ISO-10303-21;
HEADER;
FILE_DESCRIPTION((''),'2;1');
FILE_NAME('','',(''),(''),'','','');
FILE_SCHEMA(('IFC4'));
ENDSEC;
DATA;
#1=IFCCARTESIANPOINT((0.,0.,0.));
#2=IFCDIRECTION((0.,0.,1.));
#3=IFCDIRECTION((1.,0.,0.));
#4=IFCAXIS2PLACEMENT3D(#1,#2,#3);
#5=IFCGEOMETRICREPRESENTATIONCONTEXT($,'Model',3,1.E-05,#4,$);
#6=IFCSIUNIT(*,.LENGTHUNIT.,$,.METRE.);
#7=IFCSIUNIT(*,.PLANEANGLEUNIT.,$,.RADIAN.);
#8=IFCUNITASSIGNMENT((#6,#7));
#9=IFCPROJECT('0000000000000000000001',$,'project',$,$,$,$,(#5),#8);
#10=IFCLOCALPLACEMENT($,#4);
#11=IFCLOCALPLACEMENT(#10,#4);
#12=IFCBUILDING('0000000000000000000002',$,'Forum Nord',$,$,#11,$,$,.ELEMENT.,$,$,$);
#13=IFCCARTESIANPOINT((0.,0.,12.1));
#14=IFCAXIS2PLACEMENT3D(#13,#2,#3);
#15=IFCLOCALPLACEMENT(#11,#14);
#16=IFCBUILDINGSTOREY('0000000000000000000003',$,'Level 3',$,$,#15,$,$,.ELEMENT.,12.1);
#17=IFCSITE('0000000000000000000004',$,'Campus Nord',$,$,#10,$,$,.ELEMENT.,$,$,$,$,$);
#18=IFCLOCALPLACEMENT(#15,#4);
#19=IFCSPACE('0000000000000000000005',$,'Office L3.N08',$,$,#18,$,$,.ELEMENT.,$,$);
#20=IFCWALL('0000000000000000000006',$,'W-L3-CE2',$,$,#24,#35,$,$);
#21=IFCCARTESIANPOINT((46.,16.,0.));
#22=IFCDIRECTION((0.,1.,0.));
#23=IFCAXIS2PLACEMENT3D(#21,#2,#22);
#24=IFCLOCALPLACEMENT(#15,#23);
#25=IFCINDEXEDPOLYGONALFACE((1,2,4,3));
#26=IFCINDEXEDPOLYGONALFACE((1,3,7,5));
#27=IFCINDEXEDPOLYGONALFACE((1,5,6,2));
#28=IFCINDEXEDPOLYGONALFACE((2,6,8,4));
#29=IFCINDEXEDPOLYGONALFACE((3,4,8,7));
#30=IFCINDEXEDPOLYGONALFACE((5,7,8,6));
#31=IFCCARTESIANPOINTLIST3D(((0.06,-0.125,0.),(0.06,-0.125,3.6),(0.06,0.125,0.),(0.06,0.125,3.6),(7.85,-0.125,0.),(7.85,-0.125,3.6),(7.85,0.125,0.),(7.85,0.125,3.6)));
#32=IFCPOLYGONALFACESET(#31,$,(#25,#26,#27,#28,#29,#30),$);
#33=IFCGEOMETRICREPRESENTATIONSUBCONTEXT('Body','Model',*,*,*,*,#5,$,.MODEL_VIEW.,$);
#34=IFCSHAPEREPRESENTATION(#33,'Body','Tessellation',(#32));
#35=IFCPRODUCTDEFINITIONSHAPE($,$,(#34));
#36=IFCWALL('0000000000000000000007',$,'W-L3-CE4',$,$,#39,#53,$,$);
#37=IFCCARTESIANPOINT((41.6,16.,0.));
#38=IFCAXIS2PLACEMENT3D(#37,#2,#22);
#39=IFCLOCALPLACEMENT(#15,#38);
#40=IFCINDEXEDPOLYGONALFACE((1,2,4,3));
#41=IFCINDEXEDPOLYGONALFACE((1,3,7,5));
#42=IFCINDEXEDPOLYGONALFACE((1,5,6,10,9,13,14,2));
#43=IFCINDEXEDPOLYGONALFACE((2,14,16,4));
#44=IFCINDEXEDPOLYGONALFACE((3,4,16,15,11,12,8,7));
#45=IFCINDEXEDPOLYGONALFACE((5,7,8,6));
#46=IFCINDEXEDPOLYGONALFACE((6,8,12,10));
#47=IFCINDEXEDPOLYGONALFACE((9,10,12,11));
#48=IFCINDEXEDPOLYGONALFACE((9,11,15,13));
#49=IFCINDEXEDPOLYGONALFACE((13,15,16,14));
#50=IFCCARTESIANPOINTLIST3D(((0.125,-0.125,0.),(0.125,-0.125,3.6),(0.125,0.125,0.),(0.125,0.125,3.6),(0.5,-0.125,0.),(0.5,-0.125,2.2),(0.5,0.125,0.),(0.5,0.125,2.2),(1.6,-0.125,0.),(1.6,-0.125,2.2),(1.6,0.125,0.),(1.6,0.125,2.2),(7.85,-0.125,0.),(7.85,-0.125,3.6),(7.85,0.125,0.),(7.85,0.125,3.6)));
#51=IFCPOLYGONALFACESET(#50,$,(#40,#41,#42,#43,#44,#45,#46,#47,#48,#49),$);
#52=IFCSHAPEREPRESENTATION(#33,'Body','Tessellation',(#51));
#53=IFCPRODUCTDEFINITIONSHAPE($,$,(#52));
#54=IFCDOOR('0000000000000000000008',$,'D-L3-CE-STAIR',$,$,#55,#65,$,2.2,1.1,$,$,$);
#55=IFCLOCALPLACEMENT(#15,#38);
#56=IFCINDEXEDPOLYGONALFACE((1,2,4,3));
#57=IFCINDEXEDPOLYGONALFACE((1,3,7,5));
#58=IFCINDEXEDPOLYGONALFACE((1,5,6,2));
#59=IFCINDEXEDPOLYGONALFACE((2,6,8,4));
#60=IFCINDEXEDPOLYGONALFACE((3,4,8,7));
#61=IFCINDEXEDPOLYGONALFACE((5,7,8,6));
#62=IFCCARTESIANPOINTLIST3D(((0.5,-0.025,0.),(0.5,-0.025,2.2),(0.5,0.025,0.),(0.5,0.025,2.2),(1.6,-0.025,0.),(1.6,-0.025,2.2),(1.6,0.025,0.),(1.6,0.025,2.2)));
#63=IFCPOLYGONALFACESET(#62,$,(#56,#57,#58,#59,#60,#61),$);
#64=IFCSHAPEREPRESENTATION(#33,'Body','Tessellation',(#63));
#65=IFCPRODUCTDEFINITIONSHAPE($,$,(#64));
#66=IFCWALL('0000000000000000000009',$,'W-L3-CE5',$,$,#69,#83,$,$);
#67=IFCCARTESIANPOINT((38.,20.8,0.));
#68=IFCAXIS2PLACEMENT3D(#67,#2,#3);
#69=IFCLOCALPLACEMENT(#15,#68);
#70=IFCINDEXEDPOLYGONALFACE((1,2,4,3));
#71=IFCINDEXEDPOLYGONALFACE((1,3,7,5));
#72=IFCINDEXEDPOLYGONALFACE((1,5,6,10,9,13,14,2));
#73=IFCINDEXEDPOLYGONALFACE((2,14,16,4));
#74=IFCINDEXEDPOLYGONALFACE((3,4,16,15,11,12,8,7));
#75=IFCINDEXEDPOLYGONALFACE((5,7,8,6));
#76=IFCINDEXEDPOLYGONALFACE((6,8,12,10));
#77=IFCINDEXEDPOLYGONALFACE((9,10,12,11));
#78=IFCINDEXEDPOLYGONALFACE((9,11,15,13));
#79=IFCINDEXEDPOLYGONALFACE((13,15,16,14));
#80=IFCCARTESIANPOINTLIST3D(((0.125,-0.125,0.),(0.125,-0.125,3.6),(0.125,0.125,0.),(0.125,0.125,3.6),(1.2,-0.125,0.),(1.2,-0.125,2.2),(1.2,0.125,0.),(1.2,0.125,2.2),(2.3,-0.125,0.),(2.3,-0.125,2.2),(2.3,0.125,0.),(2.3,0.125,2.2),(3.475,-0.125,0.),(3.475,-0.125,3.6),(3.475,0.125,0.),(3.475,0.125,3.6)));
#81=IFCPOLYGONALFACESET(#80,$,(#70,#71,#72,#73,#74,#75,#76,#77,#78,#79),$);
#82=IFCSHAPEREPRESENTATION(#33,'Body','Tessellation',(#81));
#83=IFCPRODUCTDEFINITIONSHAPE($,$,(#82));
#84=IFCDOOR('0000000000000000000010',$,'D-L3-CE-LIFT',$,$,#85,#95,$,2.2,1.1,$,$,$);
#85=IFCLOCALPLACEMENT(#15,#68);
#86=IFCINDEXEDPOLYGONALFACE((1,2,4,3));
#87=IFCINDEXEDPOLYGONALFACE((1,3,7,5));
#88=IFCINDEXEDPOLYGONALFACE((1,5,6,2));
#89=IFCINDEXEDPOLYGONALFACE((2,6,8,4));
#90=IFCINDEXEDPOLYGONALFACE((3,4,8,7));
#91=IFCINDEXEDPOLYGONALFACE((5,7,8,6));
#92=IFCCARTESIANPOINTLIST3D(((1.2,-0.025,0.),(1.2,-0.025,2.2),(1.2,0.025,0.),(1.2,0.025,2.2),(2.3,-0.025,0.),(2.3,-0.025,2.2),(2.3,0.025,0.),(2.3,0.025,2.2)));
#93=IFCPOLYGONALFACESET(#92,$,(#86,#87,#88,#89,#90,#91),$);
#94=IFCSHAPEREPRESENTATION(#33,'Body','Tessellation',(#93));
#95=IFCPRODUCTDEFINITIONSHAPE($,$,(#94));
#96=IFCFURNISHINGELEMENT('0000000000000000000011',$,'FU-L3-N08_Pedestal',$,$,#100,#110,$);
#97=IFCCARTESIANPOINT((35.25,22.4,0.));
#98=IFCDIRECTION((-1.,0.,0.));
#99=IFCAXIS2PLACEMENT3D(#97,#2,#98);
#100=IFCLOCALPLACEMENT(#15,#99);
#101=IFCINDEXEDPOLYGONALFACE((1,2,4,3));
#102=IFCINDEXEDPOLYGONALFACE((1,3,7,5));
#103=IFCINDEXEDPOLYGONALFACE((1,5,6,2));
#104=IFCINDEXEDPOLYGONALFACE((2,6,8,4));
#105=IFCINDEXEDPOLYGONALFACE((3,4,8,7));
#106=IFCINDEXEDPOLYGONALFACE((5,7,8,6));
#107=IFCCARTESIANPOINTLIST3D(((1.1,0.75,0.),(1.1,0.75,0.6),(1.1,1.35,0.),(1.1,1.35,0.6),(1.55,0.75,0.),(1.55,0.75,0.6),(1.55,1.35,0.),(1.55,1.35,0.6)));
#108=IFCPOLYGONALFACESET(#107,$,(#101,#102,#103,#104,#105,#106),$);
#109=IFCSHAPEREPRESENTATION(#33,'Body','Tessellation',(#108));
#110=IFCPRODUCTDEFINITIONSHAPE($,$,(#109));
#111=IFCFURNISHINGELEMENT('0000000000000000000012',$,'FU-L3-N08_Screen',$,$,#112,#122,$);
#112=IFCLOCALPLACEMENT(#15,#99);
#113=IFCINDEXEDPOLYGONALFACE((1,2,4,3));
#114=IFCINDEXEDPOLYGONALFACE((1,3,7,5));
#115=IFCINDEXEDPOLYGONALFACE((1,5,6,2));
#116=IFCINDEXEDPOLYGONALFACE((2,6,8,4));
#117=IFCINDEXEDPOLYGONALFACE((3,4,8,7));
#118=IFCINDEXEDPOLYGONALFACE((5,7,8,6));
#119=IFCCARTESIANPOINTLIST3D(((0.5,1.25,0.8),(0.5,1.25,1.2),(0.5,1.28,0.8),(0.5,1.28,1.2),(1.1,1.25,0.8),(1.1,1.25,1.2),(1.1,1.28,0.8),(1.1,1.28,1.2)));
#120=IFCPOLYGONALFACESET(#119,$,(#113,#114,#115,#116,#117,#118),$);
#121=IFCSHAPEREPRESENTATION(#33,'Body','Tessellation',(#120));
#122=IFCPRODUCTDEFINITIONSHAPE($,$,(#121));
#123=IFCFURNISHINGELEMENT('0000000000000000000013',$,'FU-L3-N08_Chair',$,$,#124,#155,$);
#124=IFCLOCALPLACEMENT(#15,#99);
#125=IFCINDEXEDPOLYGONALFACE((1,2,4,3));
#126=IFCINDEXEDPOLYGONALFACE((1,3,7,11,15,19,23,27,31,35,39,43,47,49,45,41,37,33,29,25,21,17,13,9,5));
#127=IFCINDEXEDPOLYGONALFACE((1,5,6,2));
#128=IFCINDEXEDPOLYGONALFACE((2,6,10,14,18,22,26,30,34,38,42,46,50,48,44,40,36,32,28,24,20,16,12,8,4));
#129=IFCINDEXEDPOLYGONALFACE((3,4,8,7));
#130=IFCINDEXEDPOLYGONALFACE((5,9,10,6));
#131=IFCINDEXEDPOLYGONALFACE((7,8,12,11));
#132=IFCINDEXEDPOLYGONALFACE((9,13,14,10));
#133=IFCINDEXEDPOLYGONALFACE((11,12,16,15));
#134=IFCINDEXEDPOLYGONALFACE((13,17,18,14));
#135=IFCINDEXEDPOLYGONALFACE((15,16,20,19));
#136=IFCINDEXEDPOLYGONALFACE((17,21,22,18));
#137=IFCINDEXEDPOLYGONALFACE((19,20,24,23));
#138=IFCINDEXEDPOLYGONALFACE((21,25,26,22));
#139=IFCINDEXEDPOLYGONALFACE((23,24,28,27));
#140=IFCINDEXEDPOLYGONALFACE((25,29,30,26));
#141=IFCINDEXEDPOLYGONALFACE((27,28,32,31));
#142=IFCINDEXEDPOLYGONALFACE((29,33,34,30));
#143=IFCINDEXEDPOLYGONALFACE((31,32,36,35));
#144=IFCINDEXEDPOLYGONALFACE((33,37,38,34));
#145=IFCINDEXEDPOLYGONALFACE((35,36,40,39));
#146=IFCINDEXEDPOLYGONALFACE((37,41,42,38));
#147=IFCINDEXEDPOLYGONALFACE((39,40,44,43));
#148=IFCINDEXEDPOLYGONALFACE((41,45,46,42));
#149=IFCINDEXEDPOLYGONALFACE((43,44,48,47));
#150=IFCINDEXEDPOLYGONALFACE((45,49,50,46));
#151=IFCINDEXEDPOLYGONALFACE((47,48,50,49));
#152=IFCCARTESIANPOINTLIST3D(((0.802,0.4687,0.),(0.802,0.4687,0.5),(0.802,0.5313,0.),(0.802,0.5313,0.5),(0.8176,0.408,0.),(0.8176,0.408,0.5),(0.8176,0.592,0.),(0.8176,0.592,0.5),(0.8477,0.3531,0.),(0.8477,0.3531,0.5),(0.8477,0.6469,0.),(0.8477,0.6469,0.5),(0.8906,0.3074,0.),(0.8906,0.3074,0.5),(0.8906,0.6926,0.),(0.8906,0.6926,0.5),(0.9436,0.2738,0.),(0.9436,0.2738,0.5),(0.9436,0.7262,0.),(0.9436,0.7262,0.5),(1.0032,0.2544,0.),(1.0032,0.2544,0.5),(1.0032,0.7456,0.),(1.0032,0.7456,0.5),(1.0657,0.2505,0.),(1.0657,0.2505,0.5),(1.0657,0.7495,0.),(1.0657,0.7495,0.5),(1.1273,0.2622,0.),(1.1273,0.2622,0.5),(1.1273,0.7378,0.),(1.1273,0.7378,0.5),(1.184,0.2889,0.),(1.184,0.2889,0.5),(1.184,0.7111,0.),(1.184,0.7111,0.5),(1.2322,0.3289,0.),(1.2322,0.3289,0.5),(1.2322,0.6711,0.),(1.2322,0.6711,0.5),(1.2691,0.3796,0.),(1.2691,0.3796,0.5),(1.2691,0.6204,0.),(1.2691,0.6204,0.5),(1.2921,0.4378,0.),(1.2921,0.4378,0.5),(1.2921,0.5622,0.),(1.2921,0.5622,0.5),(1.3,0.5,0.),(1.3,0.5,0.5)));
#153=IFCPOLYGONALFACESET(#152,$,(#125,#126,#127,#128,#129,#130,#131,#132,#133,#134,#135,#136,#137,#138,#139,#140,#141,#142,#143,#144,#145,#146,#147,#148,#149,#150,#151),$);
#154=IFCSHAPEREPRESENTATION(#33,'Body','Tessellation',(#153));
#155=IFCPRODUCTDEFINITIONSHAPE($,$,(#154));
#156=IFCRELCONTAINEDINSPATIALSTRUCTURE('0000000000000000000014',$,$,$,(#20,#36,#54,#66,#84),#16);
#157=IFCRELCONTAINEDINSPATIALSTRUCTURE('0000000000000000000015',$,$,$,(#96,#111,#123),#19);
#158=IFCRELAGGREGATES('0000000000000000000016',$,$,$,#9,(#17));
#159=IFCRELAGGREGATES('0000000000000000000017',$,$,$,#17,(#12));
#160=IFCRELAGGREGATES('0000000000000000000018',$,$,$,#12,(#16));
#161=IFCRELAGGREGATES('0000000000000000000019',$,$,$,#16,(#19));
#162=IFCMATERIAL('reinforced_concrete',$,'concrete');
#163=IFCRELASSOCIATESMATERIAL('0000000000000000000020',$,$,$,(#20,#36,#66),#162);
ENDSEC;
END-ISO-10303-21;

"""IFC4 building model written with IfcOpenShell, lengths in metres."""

from ifc_helpers import new_model, si_unit, frame, frame_2d, origin_with_axes, place, context, subcontext, project, spatial, polyline, rectangle, circle, outline, extrude, material, element, fill, save


model = new_model("IFC4")

# Units and contexts
model_context = context("Model", 3, precision=1e-05, world=origin_with_axes())
body_context = subcontext(model_context, "Body", "Model", "MODEL_VIEW")
ifc_project = project(units=[si_unit("LENGTHUNIT", "METRE"), si_unit("PLANEANGLEUNIT", "RADIAN")], contexts=[model_context])

# Site, building, storey
site_placement = place(None, origin_with_axes())
site = spatial("IfcSite", under=ifc_project, at=site_placement, Name="Campus Nord", CompositionType="ELEMENT")
building_placement = place(site_placement, origin_with_axes())
building = spatial("IfcBuilding", under=site, at=building_placement, Name="Forum Nord", CompositionType="ELEMENT")
storey_placement = place(building_placement, frame((0.0, 0.0, 12.1), z_axis=(0.0, 0.0, 1.0), x_axis=(1.0, 0.0, 0.0)))
storey = spatial("IfcBuildingStorey", under=building, at=storey_placement, Name="Level 3", CompositionType="ELEMENT", Elevation=12.1)

# Wall
ifc_material_1 = material(Name="reinforced_concrete", Category="concrete")
wall_1_placement = place(storey_placement, frame((46.0, 16.0, 0.0), z_axis=(0.0, 0.0, 1.0), x_axis=(0.0, 1.0, 0.0)))
element("IfcWall", 1, at=wall_1_placement, inside=storey, material=ifc_material_1, Name="W-L3-CE2", context=body_context, shape_type="SweptSolid", body=[
    extrude(outline(polyline([(0.06, -0.125), (7.85, -0.125), (7.85, 0.125), (0.06, 0.125), (0.06, -0.125)])), origin_with_axes(), (0.0, 0.0, 1.0), 3.6),
])

# Walls, openings, doors
wall_2_placement = place(storey_placement, frame((41.6, 16.0, 0.0), z_axis=(0.0, 0.0, 1.0), x_axis=(0.0, 1.0, 0.0)))
wall_2 = element("IfcWall", 2, at=wall_2_placement, inside=storey, material=ifc_material_1, Name="W-L3-CE4", context=body_context, shape_type="SweptSolid", body=[
    extrude(outline(polyline([(0.125, -0.125), (7.85, -0.125), (7.85, 0.125), (0.125, 0.125), (0.125, -0.125)])), origin_with_axes(), (0.0, 0.0, 1.0), 3.6),
])
opening_1_placement = place(storey_placement, frame((41.6, 16.0, 0.0), z_axis=(0.0, 0.0, 1.0), x_axis=(0.0, 1.0, 0.0)))
opening_1 = element("IfcOpeningElement", 3, at=opening_1_placement, cuts=wall_2, context=body_context, shape_type="SweptSolid", body=[
    extrude(rectangle(XDim=1.1, YDim=0.25, at=frame_2d((1.05, 0.0), x_axis=(1.0, 0.0))), origin_with_axes(), (0.0, 0.0, 1.0), 2.2),
])
door_1_placement = place(storey_placement, frame((41.6, 16.0, 0.0), z_axis=(0.0, 0.0, 1.0), x_axis=(0.0, 1.0, 0.0)))
door_1 = element("IfcDoor", 4, at=door_1_placement, inside=storey, Name="D-L3-CE-STAIR", OverallHeight=2.2, OverallWidth=1.1, context=body_context, shape_type="SweptSolid", body=[
    extrude(rectangle(XDim=1.1, YDim=0.05, at=frame_2d((1.05, 0.0), x_axis=(1.0, 0.0))), origin_with_axes(), (0.0, 0.0, 1.0), 2.2),
])
fill(opening_1, door_1)
wall_3_placement = place(storey_placement, frame((38.0, 20.8, 0.0), z_axis=(0.0, 0.0, 1.0), x_axis=(1.0, 0.0, 0.0)))
wall_3 = element("IfcWall", 5, at=wall_3_placement, inside=storey, material=ifc_material_1, Name="W-L3-CE5", context=body_context, shape_type="SweptSolid", body=[
    extrude(outline(polyline([(0.125, -0.125), (3.475, -0.125), (3.475, 0.125), (0.125, 0.125), (0.125, -0.125)])), origin_with_axes(), (0.0, 0.0, 1.0), 3.6),
])
opening_2_placement = place(storey_placement, frame((38.0, 20.8, 0.0), z_axis=(0.0, 0.0, 1.0), x_axis=(1.0, 0.0, 0.0)))
opening_2 = element("IfcOpeningElement", 6, at=opening_2_placement, cuts=wall_3, context=body_context, shape_type="SweptSolid", body=[
    extrude(rectangle(XDim=1.1, YDim=0.25, at=frame_2d((1.75, 0.0), x_axis=(1.0, 0.0))), origin_with_axes(), (0.0, 0.0, 1.0), 2.2),
])
door_2_placement = place(storey_placement, frame((38.0, 20.8, 0.0), z_axis=(0.0, 0.0, 1.0), x_axis=(1.0, 0.0, 0.0)))
door_2 = element("IfcDoor", 7, at=door_2_placement, inside=storey, Name="D-L3-CE-LIFT", OverallHeight=2.2, OverallWidth=1.1, context=body_context, shape_type="SweptSolid", body=[
    extrude(rectangle(XDim=1.1, YDim=0.05, at=frame_2d((1.75, 0.0), x_axis=(1.0, 0.0))), origin_with_axes(), (0.0, 0.0, 1.0), 2.2),
])
fill(opening_2, door_2)

# Shared definitions
space_placement = place(storey_placement, origin_with_axes())
space = spatial("IfcSpace", under=storey, at=space_placement, Name="Office L3.N08", CompositionType="ELEMENT")

# Furnishing elements
furnishing_1_placement = place(storey_placement, frame((35.25, 22.4, 0.0), z_axis=(0.0, 0.0, 1.0), x_axis=(-1.0, 0.0, 0.0)))
element("IfcFurnishingElement", 8, at=furnishing_1_placement, inside=space, Name="FU-L3-N08_Pedestal", context=body_context, shape_type="SweptSolid", body=[
    extrude(rectangle(XDim=0.45, YDim=0.6, at=frame_2d((1.325, 1.05), x_axis=(1.0, 0.0))), origin_with_axes(), (0.0, 0.0, 1.0), 0.6),
])
furnishing_2_placement = place(storey_placement, frame((35.25, 22.4, 0.0), z_axis=(0.0, 0.0, 1.0), x_axis=(-1.0, 0.0, 0.0)))
element("IfcFurnishingElement", 9, at=furnishing_2_placement, inside=space, Name="FU-L3-N08_Screen", context=body_context, shape_type="SweptSolid", body=[
    extrude(rectangle(XDim=0.6, YDim=0.03, at=frame_2d((0.8, 1.265), x_axis=(1.0, 0.0))), frame((0.0, 0.0, 0.8), z_axis=(0.0, 0.0, 1.0), x_axis=(1.0, 0.0, 0.0)), (0.0, 0.0, 1.0), 0.4),
])
furnishing_3_placement = place(storey_placement, frame((35.25, 22.4, 0.0), z_axis=(0.0, 0.0, 1.0), x_axis=(-1.0, 0.0, 0.0)))
element("IfcFurnishingElement", 10, at=furnishing_3_placement, inside=space, Name="FU-L3-N08_Chair", context=body_context, shape_type="SweptSolid", body=[
    extrude(circle(Radius=0.25, at=frame_2d((1.05, 0.5), x_axis=(1.0, 0.0))), origin_with_axes(), (0.0, 0.0, 1.0), 0.5),
])

save(model, "model.ifc")
